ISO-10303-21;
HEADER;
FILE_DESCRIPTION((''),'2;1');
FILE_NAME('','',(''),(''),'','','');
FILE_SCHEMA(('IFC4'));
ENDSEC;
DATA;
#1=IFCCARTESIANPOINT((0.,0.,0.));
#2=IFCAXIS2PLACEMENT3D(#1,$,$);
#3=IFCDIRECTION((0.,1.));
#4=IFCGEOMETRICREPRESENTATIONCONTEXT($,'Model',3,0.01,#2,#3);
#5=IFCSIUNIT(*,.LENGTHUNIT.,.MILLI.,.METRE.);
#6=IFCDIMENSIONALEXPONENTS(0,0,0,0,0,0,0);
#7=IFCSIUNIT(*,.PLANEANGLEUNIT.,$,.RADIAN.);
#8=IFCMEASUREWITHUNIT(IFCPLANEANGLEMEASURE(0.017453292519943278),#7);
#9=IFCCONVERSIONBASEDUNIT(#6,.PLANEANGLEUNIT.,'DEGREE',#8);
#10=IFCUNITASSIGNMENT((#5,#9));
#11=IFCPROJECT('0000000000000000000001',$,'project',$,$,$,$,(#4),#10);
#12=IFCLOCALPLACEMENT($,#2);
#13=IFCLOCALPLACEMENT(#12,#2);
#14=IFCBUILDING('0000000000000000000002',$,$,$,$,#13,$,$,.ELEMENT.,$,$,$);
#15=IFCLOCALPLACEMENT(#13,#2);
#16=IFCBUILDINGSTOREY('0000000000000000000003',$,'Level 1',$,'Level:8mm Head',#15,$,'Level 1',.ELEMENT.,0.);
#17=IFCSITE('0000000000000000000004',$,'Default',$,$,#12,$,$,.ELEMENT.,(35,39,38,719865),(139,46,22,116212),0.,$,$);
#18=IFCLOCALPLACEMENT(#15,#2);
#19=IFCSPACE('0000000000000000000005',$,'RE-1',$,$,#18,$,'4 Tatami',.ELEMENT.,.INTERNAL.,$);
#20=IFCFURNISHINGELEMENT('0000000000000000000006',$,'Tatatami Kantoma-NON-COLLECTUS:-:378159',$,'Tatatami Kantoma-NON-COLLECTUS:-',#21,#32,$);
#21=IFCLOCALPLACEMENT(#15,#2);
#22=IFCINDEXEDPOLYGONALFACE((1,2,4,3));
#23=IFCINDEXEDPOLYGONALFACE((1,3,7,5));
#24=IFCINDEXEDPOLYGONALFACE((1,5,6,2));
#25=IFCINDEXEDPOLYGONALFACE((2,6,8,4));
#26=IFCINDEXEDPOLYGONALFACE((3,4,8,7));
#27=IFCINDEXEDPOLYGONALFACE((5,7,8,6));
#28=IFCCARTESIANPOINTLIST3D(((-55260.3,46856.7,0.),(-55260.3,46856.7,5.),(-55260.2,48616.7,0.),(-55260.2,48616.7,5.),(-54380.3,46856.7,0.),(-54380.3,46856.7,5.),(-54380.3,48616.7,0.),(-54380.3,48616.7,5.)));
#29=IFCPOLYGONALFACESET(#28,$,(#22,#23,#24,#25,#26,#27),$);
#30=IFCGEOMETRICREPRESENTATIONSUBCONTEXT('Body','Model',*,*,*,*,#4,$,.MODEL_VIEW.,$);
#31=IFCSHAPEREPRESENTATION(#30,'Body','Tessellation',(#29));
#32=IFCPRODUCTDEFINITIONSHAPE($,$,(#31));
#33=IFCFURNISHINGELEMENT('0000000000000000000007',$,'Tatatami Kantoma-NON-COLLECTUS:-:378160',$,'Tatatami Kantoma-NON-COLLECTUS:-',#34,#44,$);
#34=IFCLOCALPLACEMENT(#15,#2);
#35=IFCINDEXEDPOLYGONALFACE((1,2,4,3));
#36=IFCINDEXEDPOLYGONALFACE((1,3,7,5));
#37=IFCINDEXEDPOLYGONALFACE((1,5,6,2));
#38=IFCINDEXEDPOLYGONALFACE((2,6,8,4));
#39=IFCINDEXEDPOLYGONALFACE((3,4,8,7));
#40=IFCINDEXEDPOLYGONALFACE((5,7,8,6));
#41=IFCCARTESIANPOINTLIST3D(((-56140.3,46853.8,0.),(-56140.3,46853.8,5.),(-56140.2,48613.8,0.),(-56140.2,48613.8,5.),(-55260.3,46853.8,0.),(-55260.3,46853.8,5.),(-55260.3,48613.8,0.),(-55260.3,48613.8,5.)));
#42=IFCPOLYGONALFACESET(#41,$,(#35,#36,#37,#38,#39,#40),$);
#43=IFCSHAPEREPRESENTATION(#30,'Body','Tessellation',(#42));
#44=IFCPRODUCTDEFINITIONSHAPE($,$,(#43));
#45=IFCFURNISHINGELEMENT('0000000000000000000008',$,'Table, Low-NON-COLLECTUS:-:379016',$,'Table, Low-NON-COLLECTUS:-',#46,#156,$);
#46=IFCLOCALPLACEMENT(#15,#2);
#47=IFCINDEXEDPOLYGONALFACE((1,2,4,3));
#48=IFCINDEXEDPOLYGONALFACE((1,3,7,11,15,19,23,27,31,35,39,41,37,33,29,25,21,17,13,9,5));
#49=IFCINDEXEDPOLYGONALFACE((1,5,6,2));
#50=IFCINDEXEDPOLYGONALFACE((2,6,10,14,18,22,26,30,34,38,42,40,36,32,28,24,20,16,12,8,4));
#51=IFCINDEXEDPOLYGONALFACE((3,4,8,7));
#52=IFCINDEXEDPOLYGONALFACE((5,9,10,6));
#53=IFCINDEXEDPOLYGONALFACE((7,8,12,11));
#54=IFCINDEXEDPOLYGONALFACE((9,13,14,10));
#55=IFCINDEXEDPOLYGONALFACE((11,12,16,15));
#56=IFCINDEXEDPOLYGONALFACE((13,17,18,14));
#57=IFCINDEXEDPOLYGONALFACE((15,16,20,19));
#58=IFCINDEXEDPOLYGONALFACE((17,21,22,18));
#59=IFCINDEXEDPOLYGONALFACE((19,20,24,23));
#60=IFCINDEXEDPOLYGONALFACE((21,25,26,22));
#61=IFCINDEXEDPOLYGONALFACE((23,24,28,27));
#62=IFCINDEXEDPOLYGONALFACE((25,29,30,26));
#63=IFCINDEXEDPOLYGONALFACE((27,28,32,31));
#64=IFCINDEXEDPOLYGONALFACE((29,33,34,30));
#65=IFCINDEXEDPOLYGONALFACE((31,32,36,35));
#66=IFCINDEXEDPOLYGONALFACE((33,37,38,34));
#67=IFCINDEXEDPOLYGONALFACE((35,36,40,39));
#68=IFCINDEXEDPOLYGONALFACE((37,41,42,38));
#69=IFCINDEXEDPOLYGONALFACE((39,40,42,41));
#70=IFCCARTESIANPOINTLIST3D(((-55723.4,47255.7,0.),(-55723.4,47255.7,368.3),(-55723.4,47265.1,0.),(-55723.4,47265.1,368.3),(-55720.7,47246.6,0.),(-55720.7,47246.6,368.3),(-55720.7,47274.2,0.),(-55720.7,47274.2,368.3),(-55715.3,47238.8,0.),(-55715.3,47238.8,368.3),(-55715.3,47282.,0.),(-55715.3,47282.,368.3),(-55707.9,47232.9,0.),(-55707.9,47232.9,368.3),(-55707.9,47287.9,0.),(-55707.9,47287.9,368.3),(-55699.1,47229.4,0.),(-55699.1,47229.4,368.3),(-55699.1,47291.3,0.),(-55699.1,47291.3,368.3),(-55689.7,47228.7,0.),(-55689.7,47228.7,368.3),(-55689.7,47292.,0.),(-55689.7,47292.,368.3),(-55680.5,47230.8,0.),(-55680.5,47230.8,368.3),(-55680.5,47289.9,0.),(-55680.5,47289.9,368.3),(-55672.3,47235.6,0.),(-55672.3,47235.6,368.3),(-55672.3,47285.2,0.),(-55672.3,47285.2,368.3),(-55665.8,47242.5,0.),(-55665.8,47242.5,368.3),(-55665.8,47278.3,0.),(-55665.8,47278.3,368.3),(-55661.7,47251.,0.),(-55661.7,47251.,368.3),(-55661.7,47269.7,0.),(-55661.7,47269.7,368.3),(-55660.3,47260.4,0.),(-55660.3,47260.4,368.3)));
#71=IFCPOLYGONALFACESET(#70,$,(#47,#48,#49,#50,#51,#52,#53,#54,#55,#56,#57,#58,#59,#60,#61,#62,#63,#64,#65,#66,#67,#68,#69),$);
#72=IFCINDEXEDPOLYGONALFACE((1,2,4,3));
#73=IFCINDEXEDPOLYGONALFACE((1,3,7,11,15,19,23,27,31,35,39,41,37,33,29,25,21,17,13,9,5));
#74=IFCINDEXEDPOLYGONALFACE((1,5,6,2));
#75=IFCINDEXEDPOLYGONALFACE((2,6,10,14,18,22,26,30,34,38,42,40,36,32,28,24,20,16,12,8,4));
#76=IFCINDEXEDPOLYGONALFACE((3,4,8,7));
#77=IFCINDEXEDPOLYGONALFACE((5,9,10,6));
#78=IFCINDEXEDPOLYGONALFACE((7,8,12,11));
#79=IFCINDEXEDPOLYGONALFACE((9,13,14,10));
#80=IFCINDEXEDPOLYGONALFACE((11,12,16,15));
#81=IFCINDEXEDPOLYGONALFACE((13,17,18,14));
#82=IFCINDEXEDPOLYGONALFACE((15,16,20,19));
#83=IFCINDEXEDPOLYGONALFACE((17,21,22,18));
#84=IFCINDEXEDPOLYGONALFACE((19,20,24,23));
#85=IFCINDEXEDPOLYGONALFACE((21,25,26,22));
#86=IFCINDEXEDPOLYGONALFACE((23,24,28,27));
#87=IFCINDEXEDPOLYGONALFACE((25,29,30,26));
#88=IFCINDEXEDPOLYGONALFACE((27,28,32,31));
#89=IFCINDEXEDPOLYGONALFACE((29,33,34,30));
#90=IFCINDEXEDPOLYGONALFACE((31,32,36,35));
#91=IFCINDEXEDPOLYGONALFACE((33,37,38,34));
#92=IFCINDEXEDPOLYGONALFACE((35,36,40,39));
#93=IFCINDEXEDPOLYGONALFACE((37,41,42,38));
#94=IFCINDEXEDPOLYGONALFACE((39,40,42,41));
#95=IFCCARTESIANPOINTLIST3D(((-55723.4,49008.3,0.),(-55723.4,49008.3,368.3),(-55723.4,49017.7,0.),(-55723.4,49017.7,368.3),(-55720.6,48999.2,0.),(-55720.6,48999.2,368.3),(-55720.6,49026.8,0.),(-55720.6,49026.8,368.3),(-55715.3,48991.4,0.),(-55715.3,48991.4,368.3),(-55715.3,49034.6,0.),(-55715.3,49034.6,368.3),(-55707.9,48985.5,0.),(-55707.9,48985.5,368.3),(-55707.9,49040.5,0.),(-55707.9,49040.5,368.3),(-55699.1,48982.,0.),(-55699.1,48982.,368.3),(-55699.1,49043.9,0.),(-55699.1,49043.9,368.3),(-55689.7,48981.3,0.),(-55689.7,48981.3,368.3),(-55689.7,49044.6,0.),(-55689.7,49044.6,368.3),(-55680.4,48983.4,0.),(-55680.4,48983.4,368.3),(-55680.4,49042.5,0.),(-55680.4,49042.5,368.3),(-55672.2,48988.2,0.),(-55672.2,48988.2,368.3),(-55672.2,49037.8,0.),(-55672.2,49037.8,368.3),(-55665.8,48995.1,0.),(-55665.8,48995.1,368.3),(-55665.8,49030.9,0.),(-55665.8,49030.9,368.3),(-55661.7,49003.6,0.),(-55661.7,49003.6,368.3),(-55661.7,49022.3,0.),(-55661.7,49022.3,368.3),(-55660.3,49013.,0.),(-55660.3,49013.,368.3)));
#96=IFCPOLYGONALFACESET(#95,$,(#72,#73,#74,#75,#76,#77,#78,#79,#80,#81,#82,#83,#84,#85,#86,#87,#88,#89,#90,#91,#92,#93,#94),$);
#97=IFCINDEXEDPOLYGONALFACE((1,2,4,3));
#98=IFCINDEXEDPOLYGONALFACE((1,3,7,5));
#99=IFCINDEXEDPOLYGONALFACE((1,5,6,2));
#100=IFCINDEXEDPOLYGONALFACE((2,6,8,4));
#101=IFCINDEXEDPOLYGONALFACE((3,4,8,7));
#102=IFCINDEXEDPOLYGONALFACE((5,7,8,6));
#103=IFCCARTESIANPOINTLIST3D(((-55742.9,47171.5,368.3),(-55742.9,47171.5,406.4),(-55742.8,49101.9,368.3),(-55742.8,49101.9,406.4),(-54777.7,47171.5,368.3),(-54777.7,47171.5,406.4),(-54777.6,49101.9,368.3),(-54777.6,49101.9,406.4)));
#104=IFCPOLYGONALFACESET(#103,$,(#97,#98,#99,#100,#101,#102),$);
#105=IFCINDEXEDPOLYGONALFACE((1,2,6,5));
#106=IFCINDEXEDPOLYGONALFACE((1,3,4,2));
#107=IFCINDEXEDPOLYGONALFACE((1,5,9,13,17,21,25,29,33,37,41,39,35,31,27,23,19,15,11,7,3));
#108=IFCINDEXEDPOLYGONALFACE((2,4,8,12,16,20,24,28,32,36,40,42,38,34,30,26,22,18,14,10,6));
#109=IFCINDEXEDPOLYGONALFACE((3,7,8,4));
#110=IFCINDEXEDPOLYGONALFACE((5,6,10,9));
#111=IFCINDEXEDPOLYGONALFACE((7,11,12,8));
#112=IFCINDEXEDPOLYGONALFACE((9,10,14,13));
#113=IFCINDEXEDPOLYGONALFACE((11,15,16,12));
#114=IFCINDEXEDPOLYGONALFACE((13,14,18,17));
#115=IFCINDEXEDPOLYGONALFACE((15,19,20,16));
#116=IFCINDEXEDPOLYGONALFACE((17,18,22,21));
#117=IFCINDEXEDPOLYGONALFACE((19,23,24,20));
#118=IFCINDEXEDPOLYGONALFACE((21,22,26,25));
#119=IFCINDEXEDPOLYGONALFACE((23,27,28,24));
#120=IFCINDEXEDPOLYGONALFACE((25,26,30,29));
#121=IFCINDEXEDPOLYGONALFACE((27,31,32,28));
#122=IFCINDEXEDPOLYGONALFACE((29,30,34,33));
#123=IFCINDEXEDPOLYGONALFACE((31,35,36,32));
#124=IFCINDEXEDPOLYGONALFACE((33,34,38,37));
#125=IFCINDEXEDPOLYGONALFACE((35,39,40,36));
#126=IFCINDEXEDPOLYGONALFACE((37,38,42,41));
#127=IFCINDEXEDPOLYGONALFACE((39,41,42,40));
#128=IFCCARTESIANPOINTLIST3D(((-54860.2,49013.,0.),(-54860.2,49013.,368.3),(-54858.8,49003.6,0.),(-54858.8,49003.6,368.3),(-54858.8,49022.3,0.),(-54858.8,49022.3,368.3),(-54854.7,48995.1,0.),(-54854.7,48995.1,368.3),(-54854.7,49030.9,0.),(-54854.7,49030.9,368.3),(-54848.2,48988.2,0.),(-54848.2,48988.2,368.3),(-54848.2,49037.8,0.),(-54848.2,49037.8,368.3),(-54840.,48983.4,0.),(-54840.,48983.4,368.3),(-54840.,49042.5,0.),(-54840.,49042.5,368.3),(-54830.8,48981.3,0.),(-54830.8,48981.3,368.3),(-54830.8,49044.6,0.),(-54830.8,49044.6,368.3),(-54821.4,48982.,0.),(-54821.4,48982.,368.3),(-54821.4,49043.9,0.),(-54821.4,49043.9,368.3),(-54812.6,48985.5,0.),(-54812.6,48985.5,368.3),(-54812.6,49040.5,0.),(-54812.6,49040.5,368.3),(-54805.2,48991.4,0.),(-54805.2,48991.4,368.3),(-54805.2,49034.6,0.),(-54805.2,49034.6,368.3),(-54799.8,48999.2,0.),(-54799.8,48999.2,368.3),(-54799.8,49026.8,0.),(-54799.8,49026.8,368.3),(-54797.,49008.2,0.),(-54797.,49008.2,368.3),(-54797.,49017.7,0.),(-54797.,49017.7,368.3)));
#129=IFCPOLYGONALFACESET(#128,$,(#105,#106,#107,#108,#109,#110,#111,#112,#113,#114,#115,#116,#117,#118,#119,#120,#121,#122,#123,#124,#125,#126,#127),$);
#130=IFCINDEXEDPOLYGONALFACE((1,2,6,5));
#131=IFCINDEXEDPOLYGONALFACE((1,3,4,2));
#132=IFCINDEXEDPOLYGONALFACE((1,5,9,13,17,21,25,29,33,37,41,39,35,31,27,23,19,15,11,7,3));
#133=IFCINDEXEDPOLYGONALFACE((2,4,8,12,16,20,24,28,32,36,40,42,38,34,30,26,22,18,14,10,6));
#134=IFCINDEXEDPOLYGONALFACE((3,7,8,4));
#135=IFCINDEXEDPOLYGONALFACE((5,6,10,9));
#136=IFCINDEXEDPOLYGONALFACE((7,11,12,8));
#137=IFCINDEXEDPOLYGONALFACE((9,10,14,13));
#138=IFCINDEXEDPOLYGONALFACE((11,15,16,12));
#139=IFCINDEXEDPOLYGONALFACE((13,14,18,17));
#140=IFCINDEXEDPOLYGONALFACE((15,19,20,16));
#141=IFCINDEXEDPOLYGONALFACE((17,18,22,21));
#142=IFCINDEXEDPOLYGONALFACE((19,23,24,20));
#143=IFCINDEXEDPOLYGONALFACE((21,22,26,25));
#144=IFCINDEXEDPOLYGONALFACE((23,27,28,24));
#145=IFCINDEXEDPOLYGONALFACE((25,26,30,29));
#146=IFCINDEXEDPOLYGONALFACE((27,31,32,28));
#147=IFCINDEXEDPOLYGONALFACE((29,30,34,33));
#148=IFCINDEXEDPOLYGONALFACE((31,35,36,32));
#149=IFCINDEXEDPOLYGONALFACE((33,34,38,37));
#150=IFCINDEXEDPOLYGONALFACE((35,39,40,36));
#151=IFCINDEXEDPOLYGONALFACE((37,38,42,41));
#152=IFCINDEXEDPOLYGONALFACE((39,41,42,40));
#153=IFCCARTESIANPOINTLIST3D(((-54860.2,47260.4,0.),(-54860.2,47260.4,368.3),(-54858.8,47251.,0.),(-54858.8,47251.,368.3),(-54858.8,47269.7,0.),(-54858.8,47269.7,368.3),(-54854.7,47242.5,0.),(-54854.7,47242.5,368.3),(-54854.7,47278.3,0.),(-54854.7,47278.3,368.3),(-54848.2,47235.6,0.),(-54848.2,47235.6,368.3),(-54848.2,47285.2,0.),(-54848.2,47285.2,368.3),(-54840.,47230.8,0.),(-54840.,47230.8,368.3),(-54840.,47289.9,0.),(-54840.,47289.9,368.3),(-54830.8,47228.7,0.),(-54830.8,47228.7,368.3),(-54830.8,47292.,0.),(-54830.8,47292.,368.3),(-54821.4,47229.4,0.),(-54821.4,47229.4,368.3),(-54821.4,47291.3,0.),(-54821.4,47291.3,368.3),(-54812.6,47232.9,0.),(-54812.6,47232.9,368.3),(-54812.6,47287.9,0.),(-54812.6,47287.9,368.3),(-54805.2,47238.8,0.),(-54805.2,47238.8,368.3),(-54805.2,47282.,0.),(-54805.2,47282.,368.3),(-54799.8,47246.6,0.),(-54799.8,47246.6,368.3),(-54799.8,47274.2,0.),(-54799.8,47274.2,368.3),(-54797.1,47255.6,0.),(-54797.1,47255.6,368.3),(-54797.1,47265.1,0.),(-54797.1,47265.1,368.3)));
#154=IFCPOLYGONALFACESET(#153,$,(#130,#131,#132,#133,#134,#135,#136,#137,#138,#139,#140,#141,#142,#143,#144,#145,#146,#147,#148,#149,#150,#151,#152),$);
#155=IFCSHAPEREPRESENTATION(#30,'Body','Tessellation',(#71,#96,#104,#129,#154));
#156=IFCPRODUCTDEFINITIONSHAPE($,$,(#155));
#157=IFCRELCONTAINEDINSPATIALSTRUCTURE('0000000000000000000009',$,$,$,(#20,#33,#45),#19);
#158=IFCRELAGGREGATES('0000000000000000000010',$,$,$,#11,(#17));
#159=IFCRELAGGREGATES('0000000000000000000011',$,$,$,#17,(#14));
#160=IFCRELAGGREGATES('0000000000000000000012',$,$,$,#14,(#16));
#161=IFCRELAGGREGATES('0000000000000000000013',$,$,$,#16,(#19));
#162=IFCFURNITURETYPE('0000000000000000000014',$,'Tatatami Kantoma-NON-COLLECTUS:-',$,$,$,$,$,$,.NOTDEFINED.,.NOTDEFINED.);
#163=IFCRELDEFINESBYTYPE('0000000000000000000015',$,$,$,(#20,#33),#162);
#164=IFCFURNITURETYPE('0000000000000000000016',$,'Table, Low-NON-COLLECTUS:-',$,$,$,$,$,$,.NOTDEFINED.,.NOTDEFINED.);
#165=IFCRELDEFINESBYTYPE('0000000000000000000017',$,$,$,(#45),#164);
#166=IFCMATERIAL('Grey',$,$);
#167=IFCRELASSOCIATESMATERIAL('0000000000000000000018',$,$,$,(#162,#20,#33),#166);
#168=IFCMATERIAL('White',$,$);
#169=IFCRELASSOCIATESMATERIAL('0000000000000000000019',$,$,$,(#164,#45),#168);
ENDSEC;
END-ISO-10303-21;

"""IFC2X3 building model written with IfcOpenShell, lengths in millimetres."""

from ifc_helpers import new_model, entity, si_unit, converted_unit, direction, frame, frame_2d, origin, origin_2d_with_axis, place, context, subcontext, project, spatial, rectangle, circle, extrude, source, transform, mapped, material, type_object, type_shapes, element, save


model = new_model("IFC2X3")

# Units and contexts
model_context = context("Model", 3, precision=0.01, world=origin(), true_north=direction((0.0, 1.0)))
body_context = subcontext(model_context, "Body", "Model", "MODEL_VIEW")
ifc_project = project(units=[si_unit("LENGTHUNIT", "METRE", prefix="MILLI"), converted_unit("PLANEANGLEUNIT", "DEGREE", entity("IfcPlaneAngleMeasure", 0.017453292519943278), si_unit("PLANEANGLEUNIT", "RADIAN"), dimensions=[0, 0, 0, 0, 0, 0, 0])], contexts=[model_context])

# Site, building, storey
site_placement = place(None, origin())
site = spatial("IfcSite", under=ifc_project, at=site_placement, Name="Default", CompositionType="ELEMENT", RefLatitude=(35, 39, 38, 719865), RefLongitude=(139, 46, 22, 116212), RefElevation=0.0)
building_placement = place(site_placement, origin())
building = spatial("IfcBuilding", under=site, at=building_placement, CompositionType="ELEMENT")
storey_placement = place(building_placement, origin())
storey = spatial("IfcBuildingStorey", under=building, at=storey_placement, Name="Level 1", ObjectType="Level:8mm Head", LongName="Level 1", CompositionType="ELEMENT", Elevation=0.0)

# Shared definitions
ifc_material_1 = material(Name="White")

# Shared definitions
space_1_placement = place(storey_placement, origin())
space_1 = spatial("IfcSpace", under=storey, at=space_1_placement, Name="RE-1", LongName="4 Tatami", CompositionType="ELEMENT", InteriorOrExteriorSpace="INTERNAL")

# Furnishing elements
ifc_material_2 = material(Name="Grey")
furniture_type_1 = type_object("IfcFurnitureType", Name="Tatatami Kantoma-NON-COLLECTUS:-", AssemblyPlace="NOTDEFINED", material=ifc_material_2)
shared_shape_1 = source(origin(), body_context, "Body", "SweptSolid", [
    extrude(rectangle(XDim=1760.0, YDim=880.0, at=origin_2d_with_axis()), frame((880.0, 440.0, 0.0), z_axis=(0.0, 0.0, 1.0), x_axis=(-1.0, 0.0, 0.0)), (0.0, 0.0, 1.0), 5.0),
])
type_shapes(furniture_type_1, [shared_shape_1])
for number, where, z_axis, x_axis, name in (
    (1, (-55260.2, 48616.7, 0.0), (0.0, 0.0, 1.0), (-0.000004, -1.0, 0.0), "Tatatami Kantoma-NON-COLLECTUS:-:378159"),
    (2, (-56140.2, 48613.8, 0.0), (0.0, 0.0, 1.0), (-0.000004, -1.0, 0.0), "Tatatami Kantoma-NON-COLLECTUS:-:378160"),
):
    element("IfcFurnishingElement", number, at=place(space_1_placement, frame(where, z_axis=z_axis, x_axis=x_axis)), inside=space_1, type_object=furniture_type_1, material=ifc_material_2, Name=name, ObjectType="Tatatami Kantoma-NON-COLLECTUS:-", context=body_context, shape_type="MappedRepresentation", body=[
        mapped(shared_shape_1, transform((0.0, 0.0, 0.0), scale=1.0)),
    ])
furniture_type_2 = type_object("IfcFurnitureType", Name="Table, Low-NON-COLLECTUS:-", AssemblyPlace="NOTDEFINED", material=ifc_material_1)
shared_shape_2 = source(origin(), body_context, "Body", "SweptSolid", [
    extrude(circle(Radius=31.8, at=frame_2d((0.0, 0.0), x_axis=(1.0, 0.0))), frame((876.3, -431.8, 0.0), z_axis=(0.0, 0.0, 1.0), x_axis=(0.0, 1.0, 0.0)), (0.0, 0.0, 1.0), 368.3),
    extrude(circle(Radius=31.8, at=origin_2d_with_axis()), frame((-876.3, -431.8, 0.0), z_axis=(0.0, 0.0, 1.0), x_axis=(0.0, 1.0, 0.0)), (0.0, 0.0, 1.0), 368.3),
    extrude(rectangle(XDim=1930.4, YDim=965.2, at=origin_2d_with_axis()), frame((0.0, 0.0, 368.3), z_axis=(0.0, 0.0, 1.0), x_axis=(-1.0, 0.0, 0.0)), (0.0, 0.0, 1.0), 38.1),
    extrude(circle(Radius=31.8, at=origin_2d_with_axis()), frame((-876.3, 431.8, 0.0), z_axis=(0.0, 0.0, 1.0), x_axis=(0.0, -1.0, 0.0)), (0.0, 0.0, 1.0), 368.3),
    extrude(circle(Radius=31.8, at=frame_2d((0.0, 0.0), x_axis=(1.0, 0.0))), frame((876.3, 431.8, 0.0), z_axis=(0.0, 0.0, 1.0), x_axis=(0.0, -1.0, 0.0)), (0.0, 0.0, 1.0), 368.3),
])
type_shapes(furniture_type_2, [shared_shape_2])
furnishing_1_placement = place(space_1_placement, frame((-55260.2, 48136.7, 0.0), z_axis=(0.0, 0.0, 1.0), x_axis=(-0.000004, -1.0, 0.0)))
element("IfcFurnishingElement", 3, at=furnishing_1_placement, inside=space_1, type_object=furniture_type_2, material=ifc_material_1, Name="Table, Low-NON-COLLECTUS:-:379016", ObjectType="Table, Low-NON-COLLECTUS:-", context=body_context, shape_type="MappedRepresentation", body=[
    mapped(shared_shape_2, transform((0.0, 0.0, 0.0), scale=1.0)),
])

save(model, "model.ifc")
